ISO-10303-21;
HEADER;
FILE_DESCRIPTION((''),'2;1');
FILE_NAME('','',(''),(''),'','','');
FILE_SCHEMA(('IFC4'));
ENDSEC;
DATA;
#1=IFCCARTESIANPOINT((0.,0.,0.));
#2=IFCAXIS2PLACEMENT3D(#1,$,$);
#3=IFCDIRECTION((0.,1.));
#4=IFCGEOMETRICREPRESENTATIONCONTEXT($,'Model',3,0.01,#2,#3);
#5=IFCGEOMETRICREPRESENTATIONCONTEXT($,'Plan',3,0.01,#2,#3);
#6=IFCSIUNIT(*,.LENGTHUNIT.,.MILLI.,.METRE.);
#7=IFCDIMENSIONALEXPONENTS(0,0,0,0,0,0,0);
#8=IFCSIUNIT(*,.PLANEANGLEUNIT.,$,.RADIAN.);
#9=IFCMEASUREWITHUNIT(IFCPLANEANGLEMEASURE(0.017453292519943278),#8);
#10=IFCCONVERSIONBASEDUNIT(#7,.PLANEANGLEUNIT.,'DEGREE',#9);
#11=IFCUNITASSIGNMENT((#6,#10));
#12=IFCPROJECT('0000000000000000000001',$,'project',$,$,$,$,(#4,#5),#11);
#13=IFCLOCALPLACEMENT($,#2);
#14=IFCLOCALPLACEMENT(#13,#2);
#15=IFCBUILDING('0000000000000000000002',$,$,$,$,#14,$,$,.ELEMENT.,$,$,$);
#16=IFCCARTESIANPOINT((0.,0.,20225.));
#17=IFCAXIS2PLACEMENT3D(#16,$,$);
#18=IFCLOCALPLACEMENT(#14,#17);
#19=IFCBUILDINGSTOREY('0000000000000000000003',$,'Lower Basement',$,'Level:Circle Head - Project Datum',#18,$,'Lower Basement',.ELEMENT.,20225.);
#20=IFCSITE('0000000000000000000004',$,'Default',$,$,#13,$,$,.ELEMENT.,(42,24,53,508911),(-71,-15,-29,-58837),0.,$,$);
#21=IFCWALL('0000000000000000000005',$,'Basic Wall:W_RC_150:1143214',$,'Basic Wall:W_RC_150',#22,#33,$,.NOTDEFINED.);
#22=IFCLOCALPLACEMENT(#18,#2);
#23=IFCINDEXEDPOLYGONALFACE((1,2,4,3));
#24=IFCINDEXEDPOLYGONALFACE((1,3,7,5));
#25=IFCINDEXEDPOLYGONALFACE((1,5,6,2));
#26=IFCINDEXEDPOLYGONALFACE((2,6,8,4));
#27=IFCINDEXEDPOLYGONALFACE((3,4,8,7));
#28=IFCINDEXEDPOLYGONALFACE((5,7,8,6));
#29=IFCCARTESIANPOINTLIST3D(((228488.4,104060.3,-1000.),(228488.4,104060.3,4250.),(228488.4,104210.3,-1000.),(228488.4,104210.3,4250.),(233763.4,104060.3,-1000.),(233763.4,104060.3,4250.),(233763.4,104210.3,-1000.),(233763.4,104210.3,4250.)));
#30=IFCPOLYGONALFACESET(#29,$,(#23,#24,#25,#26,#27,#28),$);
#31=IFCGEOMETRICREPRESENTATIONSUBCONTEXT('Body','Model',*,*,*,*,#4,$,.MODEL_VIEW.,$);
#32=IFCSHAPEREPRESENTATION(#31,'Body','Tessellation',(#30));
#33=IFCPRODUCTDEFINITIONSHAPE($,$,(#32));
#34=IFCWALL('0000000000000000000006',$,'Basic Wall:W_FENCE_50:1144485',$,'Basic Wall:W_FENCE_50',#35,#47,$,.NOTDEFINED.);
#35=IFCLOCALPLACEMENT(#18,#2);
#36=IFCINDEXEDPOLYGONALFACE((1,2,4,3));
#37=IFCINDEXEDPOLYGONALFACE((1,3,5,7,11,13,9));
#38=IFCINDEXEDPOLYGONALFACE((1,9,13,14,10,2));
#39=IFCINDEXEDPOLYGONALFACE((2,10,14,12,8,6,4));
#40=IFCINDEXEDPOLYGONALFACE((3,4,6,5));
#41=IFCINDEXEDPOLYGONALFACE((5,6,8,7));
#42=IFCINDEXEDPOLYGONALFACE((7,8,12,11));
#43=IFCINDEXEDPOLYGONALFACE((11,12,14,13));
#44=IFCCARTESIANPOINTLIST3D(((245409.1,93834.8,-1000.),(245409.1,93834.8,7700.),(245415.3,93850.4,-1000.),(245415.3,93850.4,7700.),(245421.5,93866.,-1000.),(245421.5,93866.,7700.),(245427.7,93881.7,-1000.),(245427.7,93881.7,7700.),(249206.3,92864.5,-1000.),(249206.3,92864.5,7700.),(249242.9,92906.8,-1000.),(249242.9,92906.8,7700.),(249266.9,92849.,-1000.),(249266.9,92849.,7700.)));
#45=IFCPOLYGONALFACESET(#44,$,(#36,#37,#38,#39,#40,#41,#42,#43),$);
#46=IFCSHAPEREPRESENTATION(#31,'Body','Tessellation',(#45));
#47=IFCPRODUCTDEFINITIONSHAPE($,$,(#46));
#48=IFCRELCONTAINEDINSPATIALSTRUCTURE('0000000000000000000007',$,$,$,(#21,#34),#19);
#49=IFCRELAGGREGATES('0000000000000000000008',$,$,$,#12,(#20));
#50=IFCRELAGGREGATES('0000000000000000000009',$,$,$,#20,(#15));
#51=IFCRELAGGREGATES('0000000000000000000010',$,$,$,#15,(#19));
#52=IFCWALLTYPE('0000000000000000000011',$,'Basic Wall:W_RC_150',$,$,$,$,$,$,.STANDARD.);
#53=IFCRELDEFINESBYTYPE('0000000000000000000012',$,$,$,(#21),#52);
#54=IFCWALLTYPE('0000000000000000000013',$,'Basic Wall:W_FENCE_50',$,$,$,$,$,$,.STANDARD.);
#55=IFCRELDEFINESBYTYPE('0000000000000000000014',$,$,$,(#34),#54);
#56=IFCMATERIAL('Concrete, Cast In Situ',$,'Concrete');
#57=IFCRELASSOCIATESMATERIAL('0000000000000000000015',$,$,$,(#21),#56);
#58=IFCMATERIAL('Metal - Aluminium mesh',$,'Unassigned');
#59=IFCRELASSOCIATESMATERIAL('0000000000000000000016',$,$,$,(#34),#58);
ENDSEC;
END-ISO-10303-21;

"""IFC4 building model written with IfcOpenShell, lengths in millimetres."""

from ifc_helpers import new_model, entity, si_unit, converted_unit, direction, frame, origin, place, context, subcontext, project, spatial, line, arc, indexed_curve, outline, extrude, material, type_object, element, save


model = new_model("IFC4")

# Units and contexts
model_context = context("Model", 3, precision=0.01, world=origin(), true_north=direction((0.0, 1.0)))
plan_context = context("Plan", 3, precision=0.01, world=origin(), true_north=direction((0.0, 1.0)))
body_context = subcontext(model_context, "Body", "Model", "MODEL_VIEW")
ifc_project = project(units=[si_unit("LENGTHUNIT", "METRE", prefix="MILLI"), converted_unit("PLANEANGLEUNIT", "DEGREE", entity("IfcPlaneAngleMeasure", 0.017453292519943278), si_unit("PLANEANGLEUNIT", "RADIAN"), dimensions=[0, 0, 0, 0, 0, 0, 0])], contexts=[model_context, plan_context])

# Site, building, storey
site_placement = place(None, origin())
site = spatial("IfcSite", under=ifc_project, at=site_placement, Name="Default", CompositionType="ELEMENT", RefLatitude=(42, 24, 53, 508911), RefLongitude=(-71, -15, -29, -58837), RefElevation=0.0)
building_placement = place(site_placement, origin())
building = spatial("IfcBuilding", under=site, at=building_placement, CompositionType="ELEMENT")
storey_placement = place(building_placement, frame((0.0, 0.0, 20225.0)))
storey = spatial("IfcBuildingStorey", under=building, at=storey_placement, Name="Lower Basement", ObjectType="Level:Circle Head - Project Datum", LongName="Lower Basement", CompositionType="ELEMENT", Elevation=20225.0)

# Walls
ifc_material_1 = material(Name="Concrete, Cast In Situ", Category="Concrete")
wall_type_1 = type_object("IfcWallType", Name="Basic Wall:W_RC_150", PredefinedType="STANDARD")
wall_1_placement = place(storey_placement, frame((228488.4, 104135.3, -1000.0)))
element("IfcWall", 1, at=wall_1_placement, inside=storey, type_object=wall_type_1, material=ifc_material_1, Name="Basic Wall:W_RC_150:1143214", ObjectType="Basic Wall:W_RC_150", PredefinedType="NOTDEFINED", context=body_context, shape_type="SweptSolid", body=[
    extrude(outline(indexed_curve([(5275.0, 75.0), (0.0, 75.0), (0.0, -75.0), (5275.0, -75.0), (5275.0, 75.0)], self_intersect=False)), origin(), (0.0, 0.0, 1.0), 5250.0),
])
ifc_material_2 = material(Name="Metal - Aluminium mesh", Category="Unassigned")
wall_type_2 = type_object("IfcWallType", Name="Basic Wall:W_FENCE_50", PredefinedType="STANDARD")
wall_2_placement = place(storey_placement, frame((249273.1, 92873.2, -1000.0), z_axis=(0.0, 0.0, 1.0), x_axis=(-0.968868, 0.247576, 0.0)))
element("IfcWall", 2, at=wall_2_placement, inside=storey, type_object=wall_type_2, material=ifc_material_2, Name="Basic Wall:W_FENCE_50:1144485", ObjectType="Basic Wall:W_FENCE_50", PredefinedType="NOTDEFINED", context=body_context, shape_type="SweptSolid", body=[
    extrude(outline(indexed_curve([(3975.4, -25.0), (3978.6, 0.0), (3981.8, 25.0), (62.6, 25.0), (0.0, 25.0), (37.6, -25.0)], segments=[arc(1, 2, 3), line(3, 4, 5, 6, 1)], self_intersect=False)), origin(), (0.0, 0.0, 1.0), 8700.0),
])

save(model, "model.ifc")
